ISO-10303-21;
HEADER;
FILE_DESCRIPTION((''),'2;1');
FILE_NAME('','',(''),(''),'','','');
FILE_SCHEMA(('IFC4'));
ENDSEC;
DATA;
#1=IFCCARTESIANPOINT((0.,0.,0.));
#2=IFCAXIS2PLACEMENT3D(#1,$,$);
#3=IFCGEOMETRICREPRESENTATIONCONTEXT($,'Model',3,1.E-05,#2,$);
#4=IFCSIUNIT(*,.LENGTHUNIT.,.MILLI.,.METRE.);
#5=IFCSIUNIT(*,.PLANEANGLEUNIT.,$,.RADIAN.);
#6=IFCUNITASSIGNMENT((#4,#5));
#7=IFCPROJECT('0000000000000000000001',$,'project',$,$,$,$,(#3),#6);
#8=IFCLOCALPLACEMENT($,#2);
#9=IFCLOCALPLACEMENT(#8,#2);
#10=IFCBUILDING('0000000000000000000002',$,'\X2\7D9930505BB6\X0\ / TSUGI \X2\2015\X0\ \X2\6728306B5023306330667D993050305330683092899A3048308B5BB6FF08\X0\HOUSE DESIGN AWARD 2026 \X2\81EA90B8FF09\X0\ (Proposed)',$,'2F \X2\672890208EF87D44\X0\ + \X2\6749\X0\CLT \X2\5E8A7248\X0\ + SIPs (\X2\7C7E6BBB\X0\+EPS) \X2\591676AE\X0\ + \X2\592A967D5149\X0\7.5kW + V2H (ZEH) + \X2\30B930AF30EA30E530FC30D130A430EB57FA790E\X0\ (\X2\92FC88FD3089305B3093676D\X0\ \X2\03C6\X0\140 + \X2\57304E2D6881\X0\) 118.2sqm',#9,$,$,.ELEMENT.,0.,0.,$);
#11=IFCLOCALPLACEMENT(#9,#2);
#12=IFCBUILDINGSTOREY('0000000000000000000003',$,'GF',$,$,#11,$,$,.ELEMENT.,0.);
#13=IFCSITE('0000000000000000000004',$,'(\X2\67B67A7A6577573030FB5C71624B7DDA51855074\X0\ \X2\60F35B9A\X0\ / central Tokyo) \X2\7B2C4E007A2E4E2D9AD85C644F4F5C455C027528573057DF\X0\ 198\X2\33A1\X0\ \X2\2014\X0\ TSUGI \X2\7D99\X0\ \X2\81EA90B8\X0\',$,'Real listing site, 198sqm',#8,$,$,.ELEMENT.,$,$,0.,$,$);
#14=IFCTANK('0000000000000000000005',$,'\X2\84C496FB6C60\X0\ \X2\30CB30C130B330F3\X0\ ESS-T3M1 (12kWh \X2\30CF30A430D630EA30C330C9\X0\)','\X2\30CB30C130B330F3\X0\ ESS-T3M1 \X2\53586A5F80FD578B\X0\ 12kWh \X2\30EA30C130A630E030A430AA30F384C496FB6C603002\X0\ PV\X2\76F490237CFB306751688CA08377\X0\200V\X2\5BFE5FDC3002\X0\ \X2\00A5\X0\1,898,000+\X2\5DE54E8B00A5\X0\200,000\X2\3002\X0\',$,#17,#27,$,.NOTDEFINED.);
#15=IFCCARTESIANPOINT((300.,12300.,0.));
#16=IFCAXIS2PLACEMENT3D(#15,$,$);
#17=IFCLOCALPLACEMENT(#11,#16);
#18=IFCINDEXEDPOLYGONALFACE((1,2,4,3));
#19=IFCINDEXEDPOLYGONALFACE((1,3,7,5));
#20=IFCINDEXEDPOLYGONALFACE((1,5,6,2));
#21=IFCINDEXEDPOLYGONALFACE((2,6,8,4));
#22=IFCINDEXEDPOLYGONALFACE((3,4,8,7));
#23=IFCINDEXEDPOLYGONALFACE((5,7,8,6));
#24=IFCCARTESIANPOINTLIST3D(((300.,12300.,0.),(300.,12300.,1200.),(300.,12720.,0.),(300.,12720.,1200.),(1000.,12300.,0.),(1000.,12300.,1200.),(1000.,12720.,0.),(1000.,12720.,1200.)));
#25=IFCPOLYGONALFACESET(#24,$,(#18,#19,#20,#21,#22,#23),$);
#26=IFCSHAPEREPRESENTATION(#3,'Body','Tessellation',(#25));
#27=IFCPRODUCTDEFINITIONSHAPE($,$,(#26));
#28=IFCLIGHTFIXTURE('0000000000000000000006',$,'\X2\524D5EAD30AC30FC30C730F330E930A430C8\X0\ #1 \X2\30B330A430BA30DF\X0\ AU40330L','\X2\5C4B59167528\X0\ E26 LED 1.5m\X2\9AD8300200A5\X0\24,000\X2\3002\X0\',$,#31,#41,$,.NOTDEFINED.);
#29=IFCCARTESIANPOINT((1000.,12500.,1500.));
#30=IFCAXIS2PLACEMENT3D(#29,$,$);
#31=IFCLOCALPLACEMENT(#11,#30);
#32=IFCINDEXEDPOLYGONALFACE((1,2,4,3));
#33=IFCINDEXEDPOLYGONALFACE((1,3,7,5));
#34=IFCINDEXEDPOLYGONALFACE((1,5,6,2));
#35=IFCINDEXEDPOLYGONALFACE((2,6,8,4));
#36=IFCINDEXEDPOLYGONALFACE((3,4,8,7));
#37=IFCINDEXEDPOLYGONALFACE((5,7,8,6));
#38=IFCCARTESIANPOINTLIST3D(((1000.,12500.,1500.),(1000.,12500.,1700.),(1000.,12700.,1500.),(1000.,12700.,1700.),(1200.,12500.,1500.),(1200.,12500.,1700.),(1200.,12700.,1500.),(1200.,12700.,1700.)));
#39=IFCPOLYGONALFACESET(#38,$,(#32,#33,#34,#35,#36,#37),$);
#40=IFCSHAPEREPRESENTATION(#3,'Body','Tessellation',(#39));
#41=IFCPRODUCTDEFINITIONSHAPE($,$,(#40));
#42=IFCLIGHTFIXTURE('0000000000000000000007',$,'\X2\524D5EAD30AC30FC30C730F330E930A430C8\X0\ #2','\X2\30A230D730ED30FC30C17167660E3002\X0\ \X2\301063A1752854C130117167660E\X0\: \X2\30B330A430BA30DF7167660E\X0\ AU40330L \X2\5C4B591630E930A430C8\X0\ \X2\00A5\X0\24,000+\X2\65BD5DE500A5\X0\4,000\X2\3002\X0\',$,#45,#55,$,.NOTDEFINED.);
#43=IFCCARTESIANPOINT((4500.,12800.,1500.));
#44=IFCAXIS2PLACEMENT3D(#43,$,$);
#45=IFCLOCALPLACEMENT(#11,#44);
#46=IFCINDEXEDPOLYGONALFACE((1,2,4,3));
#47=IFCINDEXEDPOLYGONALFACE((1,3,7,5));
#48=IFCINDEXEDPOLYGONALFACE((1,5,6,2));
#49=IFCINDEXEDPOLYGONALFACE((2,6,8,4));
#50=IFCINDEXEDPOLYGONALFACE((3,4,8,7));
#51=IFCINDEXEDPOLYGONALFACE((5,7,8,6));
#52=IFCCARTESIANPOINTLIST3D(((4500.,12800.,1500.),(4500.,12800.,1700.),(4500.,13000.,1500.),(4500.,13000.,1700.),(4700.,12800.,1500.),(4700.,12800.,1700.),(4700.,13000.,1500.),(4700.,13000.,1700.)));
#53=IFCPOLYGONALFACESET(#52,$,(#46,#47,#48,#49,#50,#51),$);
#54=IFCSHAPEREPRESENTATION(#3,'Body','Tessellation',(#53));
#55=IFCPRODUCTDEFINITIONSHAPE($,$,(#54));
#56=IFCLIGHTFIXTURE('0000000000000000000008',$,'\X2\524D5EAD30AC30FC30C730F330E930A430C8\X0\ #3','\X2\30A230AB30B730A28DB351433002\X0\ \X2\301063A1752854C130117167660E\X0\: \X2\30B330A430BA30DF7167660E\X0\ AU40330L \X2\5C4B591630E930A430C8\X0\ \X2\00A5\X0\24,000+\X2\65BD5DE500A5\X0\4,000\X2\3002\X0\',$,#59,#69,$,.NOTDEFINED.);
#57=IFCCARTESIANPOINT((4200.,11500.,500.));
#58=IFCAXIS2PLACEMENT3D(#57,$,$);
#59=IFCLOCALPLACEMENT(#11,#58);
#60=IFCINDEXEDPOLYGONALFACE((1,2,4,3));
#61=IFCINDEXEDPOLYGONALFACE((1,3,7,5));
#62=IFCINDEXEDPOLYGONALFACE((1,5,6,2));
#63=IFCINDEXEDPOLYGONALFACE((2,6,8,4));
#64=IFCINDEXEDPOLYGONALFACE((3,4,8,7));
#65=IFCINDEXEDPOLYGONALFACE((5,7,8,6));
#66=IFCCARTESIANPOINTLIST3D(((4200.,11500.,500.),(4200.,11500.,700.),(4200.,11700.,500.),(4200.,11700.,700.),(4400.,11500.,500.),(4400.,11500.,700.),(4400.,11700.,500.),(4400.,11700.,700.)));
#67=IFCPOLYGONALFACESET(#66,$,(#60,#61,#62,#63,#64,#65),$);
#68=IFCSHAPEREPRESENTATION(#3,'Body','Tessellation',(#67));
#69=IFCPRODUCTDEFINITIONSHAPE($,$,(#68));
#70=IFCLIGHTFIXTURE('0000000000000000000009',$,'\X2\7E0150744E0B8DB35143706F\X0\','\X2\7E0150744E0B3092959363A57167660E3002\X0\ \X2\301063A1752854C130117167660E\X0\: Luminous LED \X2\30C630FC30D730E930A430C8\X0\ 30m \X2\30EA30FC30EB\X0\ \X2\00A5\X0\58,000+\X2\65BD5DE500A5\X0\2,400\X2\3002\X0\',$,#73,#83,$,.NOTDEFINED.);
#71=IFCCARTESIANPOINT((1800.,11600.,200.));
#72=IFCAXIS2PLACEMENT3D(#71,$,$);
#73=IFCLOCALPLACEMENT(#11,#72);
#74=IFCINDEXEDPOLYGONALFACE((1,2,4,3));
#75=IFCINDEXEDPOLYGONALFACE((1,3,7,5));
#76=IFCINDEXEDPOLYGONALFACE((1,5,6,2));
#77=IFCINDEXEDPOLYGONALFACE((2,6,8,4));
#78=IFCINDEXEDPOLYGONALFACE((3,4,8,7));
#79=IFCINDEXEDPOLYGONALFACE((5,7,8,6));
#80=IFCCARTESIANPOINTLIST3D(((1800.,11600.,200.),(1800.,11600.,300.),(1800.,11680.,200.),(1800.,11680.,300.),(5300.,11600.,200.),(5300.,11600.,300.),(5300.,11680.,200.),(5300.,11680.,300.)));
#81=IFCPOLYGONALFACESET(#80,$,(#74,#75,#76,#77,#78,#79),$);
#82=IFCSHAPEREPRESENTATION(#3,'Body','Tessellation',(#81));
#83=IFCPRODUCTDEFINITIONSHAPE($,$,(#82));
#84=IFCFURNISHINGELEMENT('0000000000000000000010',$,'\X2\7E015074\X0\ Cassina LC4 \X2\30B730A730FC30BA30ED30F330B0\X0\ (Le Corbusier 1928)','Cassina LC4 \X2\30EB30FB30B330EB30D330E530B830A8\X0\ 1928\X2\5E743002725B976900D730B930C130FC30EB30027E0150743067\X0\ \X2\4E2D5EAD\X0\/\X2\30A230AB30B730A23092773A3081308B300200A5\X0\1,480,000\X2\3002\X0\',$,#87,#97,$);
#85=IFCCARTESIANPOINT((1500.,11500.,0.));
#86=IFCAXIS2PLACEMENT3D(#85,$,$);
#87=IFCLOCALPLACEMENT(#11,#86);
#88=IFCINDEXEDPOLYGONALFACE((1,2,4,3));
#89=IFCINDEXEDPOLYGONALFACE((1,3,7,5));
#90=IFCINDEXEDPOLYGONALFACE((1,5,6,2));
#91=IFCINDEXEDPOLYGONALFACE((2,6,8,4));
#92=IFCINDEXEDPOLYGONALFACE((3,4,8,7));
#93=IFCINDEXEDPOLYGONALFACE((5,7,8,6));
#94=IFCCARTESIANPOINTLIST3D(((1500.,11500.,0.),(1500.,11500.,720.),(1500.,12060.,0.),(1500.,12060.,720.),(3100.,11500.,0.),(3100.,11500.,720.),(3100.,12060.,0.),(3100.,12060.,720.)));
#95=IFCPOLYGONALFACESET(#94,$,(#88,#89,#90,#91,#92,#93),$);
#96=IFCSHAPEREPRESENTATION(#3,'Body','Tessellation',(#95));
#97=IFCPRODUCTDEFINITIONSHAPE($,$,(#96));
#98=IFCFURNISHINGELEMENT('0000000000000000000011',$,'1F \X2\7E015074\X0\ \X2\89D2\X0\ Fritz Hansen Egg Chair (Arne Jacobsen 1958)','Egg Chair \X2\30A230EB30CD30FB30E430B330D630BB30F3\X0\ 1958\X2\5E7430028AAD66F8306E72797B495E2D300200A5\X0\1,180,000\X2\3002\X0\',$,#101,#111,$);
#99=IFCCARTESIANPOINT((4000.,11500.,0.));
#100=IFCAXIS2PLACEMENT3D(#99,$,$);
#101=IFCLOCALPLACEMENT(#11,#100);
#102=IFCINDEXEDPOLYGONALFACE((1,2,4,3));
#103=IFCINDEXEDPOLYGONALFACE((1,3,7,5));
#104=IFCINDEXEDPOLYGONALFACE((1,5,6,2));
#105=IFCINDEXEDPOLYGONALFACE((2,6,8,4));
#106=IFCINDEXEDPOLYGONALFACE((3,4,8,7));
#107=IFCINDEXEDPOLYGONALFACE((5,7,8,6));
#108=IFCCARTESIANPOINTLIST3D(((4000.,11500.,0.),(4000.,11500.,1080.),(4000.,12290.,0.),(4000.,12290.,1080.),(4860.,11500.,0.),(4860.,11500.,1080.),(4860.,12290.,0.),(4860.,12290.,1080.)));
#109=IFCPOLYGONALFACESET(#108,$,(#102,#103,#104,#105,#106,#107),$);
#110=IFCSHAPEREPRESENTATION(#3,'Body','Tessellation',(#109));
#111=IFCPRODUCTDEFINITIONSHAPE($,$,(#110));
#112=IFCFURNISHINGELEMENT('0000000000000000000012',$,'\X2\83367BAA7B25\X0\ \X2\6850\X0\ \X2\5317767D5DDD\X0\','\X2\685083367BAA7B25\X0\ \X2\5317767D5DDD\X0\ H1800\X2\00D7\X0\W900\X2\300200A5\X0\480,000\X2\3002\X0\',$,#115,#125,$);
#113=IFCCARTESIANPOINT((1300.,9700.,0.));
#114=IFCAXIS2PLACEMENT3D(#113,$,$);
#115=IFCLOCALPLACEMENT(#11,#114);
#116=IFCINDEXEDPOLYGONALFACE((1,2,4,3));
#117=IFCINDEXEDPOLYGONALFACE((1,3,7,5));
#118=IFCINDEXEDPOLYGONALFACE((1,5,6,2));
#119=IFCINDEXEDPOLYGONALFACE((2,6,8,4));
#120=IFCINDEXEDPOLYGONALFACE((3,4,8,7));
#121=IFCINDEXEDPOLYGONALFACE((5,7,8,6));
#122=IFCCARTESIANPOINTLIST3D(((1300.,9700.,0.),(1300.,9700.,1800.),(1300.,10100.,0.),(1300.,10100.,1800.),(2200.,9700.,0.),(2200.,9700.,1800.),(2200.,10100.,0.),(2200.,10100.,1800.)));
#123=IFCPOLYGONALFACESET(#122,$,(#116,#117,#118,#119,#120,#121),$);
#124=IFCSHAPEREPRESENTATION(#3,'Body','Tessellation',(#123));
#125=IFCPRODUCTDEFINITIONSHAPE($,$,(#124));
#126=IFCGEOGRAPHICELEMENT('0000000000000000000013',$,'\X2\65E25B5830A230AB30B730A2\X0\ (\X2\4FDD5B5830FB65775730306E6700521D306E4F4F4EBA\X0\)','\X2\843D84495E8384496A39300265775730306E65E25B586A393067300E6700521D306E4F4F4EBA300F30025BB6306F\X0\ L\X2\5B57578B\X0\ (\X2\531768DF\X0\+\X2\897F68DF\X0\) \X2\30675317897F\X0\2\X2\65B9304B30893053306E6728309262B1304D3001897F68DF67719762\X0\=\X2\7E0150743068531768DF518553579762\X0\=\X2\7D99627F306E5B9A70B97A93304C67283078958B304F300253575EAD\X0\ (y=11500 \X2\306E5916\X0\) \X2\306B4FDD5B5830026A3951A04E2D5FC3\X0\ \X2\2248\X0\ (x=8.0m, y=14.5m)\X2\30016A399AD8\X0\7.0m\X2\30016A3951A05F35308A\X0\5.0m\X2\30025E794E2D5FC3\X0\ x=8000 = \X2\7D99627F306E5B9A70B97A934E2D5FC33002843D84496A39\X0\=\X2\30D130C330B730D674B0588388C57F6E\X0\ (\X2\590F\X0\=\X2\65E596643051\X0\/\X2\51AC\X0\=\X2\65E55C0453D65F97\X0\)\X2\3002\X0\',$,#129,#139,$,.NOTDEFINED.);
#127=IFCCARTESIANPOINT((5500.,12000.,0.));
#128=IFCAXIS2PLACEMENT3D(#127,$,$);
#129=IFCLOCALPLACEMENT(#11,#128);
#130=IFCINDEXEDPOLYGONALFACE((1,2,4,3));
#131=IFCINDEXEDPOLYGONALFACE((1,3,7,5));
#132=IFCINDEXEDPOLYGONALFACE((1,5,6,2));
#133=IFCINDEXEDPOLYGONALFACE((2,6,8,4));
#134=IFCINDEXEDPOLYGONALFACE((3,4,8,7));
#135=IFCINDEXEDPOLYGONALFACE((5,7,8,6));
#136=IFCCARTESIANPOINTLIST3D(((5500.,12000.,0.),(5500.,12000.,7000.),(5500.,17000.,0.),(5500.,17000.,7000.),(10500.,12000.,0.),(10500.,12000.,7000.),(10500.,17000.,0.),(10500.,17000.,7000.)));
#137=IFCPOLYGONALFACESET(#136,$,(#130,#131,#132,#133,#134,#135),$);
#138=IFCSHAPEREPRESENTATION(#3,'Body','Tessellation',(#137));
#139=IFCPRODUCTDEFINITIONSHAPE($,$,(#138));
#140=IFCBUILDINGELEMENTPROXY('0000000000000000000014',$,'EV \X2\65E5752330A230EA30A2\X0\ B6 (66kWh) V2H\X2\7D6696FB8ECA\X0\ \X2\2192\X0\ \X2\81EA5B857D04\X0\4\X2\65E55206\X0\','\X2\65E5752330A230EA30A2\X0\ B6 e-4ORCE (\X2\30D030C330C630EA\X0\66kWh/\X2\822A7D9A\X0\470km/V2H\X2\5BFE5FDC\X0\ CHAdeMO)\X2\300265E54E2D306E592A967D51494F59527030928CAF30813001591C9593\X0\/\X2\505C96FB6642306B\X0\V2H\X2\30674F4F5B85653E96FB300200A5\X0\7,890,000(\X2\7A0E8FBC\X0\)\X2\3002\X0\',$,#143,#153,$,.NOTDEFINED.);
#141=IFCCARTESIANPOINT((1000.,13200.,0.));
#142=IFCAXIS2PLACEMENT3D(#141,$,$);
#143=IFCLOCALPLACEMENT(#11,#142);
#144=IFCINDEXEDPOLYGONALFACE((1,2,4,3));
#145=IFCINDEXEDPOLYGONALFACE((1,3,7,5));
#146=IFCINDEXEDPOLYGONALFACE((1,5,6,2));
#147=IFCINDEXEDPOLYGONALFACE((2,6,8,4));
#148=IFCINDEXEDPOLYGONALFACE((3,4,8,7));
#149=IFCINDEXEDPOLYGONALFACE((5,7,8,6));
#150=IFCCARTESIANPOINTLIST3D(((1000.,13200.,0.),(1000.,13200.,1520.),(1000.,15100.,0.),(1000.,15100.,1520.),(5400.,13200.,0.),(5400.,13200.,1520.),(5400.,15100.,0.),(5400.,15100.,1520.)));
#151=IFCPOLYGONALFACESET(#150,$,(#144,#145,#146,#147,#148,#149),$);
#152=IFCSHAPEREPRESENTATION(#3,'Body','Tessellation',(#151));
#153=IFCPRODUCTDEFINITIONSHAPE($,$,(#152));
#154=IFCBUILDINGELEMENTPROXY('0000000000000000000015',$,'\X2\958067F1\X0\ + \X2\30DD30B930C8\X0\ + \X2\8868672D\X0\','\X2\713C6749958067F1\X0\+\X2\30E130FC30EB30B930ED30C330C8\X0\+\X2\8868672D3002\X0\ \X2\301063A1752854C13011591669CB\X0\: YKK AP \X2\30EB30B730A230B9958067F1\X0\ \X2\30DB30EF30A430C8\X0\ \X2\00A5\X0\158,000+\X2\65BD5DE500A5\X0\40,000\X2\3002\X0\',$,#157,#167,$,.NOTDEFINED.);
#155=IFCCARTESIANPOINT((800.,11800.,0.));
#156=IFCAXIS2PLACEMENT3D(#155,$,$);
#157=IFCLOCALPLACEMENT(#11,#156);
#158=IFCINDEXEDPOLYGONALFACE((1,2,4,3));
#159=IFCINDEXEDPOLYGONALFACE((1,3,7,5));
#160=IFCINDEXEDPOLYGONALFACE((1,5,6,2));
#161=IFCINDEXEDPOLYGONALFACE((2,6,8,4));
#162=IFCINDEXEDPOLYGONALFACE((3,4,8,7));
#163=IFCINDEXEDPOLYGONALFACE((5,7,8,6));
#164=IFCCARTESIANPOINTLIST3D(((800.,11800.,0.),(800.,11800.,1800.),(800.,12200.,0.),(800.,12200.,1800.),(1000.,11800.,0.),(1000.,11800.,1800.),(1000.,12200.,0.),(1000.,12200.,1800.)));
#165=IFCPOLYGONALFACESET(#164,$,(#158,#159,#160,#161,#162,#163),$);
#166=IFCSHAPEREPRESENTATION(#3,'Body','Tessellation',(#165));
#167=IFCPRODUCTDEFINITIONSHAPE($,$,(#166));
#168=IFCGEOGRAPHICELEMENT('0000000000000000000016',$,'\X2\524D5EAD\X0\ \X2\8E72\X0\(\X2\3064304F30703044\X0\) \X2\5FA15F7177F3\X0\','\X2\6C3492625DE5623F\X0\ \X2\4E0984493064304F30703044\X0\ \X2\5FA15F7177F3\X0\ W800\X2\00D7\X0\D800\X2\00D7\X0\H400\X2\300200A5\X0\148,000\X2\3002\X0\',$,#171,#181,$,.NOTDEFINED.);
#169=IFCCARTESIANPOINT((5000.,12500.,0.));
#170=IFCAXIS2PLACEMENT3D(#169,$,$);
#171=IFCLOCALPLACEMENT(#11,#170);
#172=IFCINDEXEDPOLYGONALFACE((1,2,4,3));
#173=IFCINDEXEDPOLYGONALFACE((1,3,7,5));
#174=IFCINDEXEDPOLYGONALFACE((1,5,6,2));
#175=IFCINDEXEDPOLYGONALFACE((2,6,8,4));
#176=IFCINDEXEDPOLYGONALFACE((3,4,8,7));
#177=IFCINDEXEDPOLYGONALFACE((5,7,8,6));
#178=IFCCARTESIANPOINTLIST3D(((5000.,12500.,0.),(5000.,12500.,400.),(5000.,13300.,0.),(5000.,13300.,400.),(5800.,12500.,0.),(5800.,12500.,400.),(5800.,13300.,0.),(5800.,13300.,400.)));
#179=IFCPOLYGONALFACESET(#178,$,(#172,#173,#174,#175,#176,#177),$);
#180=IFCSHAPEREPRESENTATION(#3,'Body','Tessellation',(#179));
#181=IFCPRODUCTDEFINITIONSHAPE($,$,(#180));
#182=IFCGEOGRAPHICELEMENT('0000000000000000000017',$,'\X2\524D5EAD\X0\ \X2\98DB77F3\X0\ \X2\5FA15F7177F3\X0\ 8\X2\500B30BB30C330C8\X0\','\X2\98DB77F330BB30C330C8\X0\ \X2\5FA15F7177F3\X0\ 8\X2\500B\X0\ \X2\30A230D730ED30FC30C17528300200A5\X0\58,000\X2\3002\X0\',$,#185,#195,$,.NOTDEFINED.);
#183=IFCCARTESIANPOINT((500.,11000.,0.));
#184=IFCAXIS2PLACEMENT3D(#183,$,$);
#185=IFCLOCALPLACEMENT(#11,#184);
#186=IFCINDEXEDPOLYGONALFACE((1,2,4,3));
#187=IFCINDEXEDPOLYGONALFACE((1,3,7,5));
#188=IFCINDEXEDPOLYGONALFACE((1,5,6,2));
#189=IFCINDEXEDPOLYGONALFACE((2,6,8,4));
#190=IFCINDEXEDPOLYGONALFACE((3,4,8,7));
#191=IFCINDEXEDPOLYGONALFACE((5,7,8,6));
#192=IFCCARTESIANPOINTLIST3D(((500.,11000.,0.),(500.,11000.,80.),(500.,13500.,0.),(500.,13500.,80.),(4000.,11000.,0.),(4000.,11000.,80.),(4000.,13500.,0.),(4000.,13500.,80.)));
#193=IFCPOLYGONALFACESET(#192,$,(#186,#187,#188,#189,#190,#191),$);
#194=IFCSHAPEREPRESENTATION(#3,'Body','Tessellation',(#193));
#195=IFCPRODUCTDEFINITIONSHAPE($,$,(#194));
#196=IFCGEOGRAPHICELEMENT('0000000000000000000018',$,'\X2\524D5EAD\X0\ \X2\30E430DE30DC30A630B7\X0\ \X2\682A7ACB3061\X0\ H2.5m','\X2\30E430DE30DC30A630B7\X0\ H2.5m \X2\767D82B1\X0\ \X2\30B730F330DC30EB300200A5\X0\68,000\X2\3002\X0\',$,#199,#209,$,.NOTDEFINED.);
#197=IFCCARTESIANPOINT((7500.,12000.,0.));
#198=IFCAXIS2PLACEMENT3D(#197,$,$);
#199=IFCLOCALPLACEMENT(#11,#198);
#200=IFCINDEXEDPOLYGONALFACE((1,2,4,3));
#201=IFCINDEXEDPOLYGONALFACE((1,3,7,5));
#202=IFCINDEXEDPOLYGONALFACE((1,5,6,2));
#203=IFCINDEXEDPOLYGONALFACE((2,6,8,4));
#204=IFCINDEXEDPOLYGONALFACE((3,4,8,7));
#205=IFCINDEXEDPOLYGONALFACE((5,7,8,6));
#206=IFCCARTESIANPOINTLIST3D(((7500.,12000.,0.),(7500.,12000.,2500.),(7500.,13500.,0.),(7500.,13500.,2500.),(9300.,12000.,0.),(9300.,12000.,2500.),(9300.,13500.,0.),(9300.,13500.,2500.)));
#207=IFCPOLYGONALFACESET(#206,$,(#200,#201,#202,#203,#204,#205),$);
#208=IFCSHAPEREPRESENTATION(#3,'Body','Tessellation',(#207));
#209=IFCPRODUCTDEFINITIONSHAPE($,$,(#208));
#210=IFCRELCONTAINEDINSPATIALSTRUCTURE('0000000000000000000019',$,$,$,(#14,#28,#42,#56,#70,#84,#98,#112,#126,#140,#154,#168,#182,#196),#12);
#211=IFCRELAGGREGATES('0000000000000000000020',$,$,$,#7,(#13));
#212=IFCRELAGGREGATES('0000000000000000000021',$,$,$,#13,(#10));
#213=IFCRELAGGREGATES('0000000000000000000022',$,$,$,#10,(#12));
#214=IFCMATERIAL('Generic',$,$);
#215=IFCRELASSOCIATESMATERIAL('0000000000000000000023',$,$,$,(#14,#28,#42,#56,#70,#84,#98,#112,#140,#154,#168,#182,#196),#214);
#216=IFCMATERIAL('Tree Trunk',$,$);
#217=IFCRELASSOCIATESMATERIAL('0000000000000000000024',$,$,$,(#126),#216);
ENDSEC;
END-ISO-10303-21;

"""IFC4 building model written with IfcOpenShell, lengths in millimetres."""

from ifc_helpers import new_model, si_unit, frame, frame_2d, origin, place, context, project, spatial, rectangle, extrude, material, element, save


model = new_model("IFC4")

# Units and contexts
model_context = context("Model", 3, precision=1e-05, world=origin())
ifc_project = project(units=[si_unit("LENGTHUNIT", "METRE", prefix="MILLI"), si_unit("PLANEANGLEUNIT", "RADIAN")], contexts=[model_context])

# Site, building, storey
site_placement = place(None, origin())
site = spatial("IfcSite", under=ifc_project, at=site_placement, Name="(架空敷地・山手線内側 想定 / central Tokyo) 第一種中高層住居専用地域 198㎡ — TSUGI 継 自邸", ObjectType="Real listing site, 198sqm", CompositionType="ELEMENT", RefElevation=0.0)
building_placement = place(site_placement, origin())
building = spatial("IfcBuilding", under=site, at=building_placement, Name="継ぐ家 / TSUGI ― 木に倣って継ぐことを覚える家（HOUSE DESIGN AWARD 2026 自邸） (Proposed)", ObjectType="2F 木造軸組 + 杉CLT 床版 + SIPs (籾殻+EPS) 外皮 + 太陽光7.5kW + V2H (ZEH) + スクリューパイル基礎 (鋼製らせん杭 φ140 + 地中梁) 118.2sqm", CompositionType="ELEMENT", ElevationOfRefHeight=0.0, ElevationOfTerrain=0.0)
storey_placement = place(building_placement, origin())
storey = spatial("IfcBuildingStorey", under=building, at=storey_placement, Name="GF", CompositionType="ELEMENT", Elevation=0.0)

# Shared definitions
ifc_material_1 = material(Name="Generic")

# Tank
tank_placement = place(storey_placement, frame((300.0, 12300.0, 0.0)))
element("IfcTank", 1, at=tank_placement, inside=storey, material=ifc_material_1, Name="蓄電池 ニチコン ESS-T3M1 (12kWh ハイブリッド)", Description="ニチコン ESS-T3M1 単機能型 12kWh リチウムイオン蓄電池。 PV直連系で全負荷200V対応。 ¥1,898,000+工事¥200,000。", PredefinedType="NOTDEFINED", context=model_context, shape_type="SweptSolid", body=[
    extrude(rectangle(XDim=700.0, YDim=420.0, at=frame_2d((350.0, 210.0))), frame((300.0, 12300.0, 0.0)), (0.0, 0.0, 1.0), 1200.0),
])

# Light fixtures
light_fixture_1_placement = place(storey_placement, frame((1000.0, 12500.0, 1500.0)))
element("IfcLightFixture", 2, at=light_fixture_1_placement, inside=storey, material=ifc_material_1, Name="前庭ガーデンライト #1 コイズミ AU40330L", Description="屋外用 E26 LED 1.5m高。¥24,000。", PredefinedType="NOTDEFINED", context=model_context, shape_type="SweptSolid", body=[
    extrude(rectangle(XDim=200.0, YDim=200.0, at=frame_2d((100.0, 100.0))), frame((1000.0, 12500.0, 1500.0)), (0.0, 0.0, 1.0), 200.0),
])
light_fixture_2_placement = place(storey_placement, frame((4500.0, 12800.0, 1500.0)))
element("IfcLightFixture", 3, at=light_fixture_2_placement, inside=storey, material=ifc_material_1, Name="前庭ガーデンライト #2", Description="アプローチ照明。 【採用品】照明: コイズミ照明 AU40330L 屋外ライト ¥24,000+施工¥4,000。", PredefinedType="NOTDEFINED", context=model_context, shape_type="SweptSolid", body=[
    extrude(rectangle(XDim=200.0, YDim=200.0, at=frame_2d((100.0, 100.0))), frame((4500.0, 12800.0, 1500.0)), (0.0, 0.0, 1.0), 200.0),
])
light_fixture_3_placement = place(storey_placement, frame((4200.0, 11500.0, 500.0)))
element("IfcLightFixture", 4, at=light_fixture_3_placement, inside=storey, material=ifc_material_1, Name="前庭ガーデンライト #3", Description="アカシア足元。 【採用品】照明: コイズミ照明 AU40330L 屋外ライト ¥24,000+施工¥4,000。", PredefinedType="NOTDEFINED", context=model_context, shape_type="SweptSolid", body=[
    extrude(rectangle(XDim=200.0, YDim=200.0, at=frame_2d((100.0, 100.0))), frame((4200.0, 11500.0, 500.0)), (0.0, 0.0, 1.0), 200.0),
])
light_fixture_4_placement = place(storey_placement, frame((1800.0, 11600.0, 200.0)))
element("IfcLightFixture", 5, at=light_fixture_4_placement, inside=storey, material=ifc_material_1, Name="縁側下足元灯", Description="縁側下を間接照明。 【採用品】照明: Luminous LED テープライト 30m リール ¥58,000+施工¥2,400。", PredefinedType="NOTDEFINED", context=model_context, shape_type="SweptSolid", body=[
    extrude(rectangle(XDim=3500.0, YDim=80.0, at=frame_2d((1750.0, 40.0))), frame((1800.0, 11600.0, 200.0)), (0.0, 0.0, 1.0), 100.0),
])

# Furnishing elements
furnishing_1_placement = place(storey_placement, frame((1500.0, 11500.0, 0.0)))
element("IfcFurnishingElement", 6, at=furnishing_1_placement, inside=storey, material=ifc_material_1, Name="縁側 Cassina LC4 シェーズロング (Le Corbusier 1928)", Description="Cassina LC4 ル・コルビュジエ 1928年。牛革×スチール。縁側で 中庭/アカシアを眺める。¥1,480,000。", context=model_context, shape_type="SweptSolid", body=[
    extrude(rectangle(XDim=1600.0, YDim=560.0, at=frame_2d((800.0, 280.0))), frame((1500.0, 11500.0, 0.0)), (0.0, 0.0, 1.0), 720.0),
])
furnishing_2_placement = place(storey_placement, frame((4000.0, 11500.0, 0.0)))
element("IfcFurnishingElement", 7, at=furnishing_2_placement, inside=storey, material=ifc_material_1, Name="1F 縁側 角 Fritz Hansen Egg Chair (Arne Jacobsen 1958)", Description="Egg Chair アルネ・ヤコブセン 1958年。読書の特等席。¥1,180,000。", context=model_context, shape_type="SweptSolid", body=[
    extrude(rectangle(XDim=860.0, YDim=790.0, at=frame_2d((430.0, 395.0))), frame((4000.0, 11500.0, 0.0)), (0.0, 0.0, 1.0), 1080.0),
])
furnishing_3_placement = place(storey_placement, frame((1300.0, 9700.0, 0.0)))
element("IfcFurnishingElement", 8, at=furnishing_3_placement, inside=storey, material=ifc_material_1, Name="茶箪笥 桐 北白川", Description="桐茶箪笥 北白川 H1800×W900。¥480,000。", context=model_context, shape_type="SweptSolid", body=[
    extrude(rectangle(XDim=900.0, YDim=400.0, at=frame_2d((450.0, 200.0))), frame((1300.0, 9700.0, 0.0)), (0.0, 0.0, 1.0), 1800.0),
])

# Geographic element
ifc_material_2 = material(Name="Tree Trunk")
geographic_element_1_placement = place(storey_placement, frame((5500.0, 12000.0, 0.0)))
element("IfcGeographicElement", 9, at=geographic_element_1_placement, inside=storey, material=ifc_material_2, Name="既存アカシア (保存・敷地の最初の住人)", Description="落葉広葉樹。敷地の既存樹で『最初の住人』。家は L字型 (北棟+西棟) で北西2方からこの木を抱き、西棟東面=縁側と北棟内南面=継承の定点窓が木へ開く。南庭 (y=11500 の外) に保存。樹冠中心 ≈ (x=8.0m, y=14.5m)、樹高7.0m、樹冠張り5.0m。幹中心 x=8000 = 継承の定点窓中心。落葉樹=パッシブ環境装置 (夏=日除け/冬=日射取得)。", PredefinedType="NOTDEFINED", context=model_context, shape_type="SweptSolid", body=[
    extrude(rectangle(XDim=5000.0, YDim=5000.0, at=frame_2d((2500.0, 2500.0))), frame((5500.0, 12000.0, 0.0)), (0.0, 0.0, 1.0), 7000.0),
])

# Building element proxies
proxy_1_placement = place(storey_placement, frame((1000.0, 13200.0, 0.0)))
element("IfcBuildingElementProxy", 10, at=proxy_1_placement, inside=storey, material=ifc_material_1, Name="EV 日産アリア B6 (66kWh) V2H給電車 → 自宅約4日分", Description="日産アリア B6 e-4ORCE (バッテリ66kWh/航続470km/V2H対応 CHAdeMO)。日中の太陽光余剰を貯め、夜間/停電時にV2Hで住宅放電。¥7,890,000(税込)。", PredefinedType="NOTDEFINED", context=model_context, shape_type="SweptSolid", body=[
    extrude(rectangle(XDim=4400.0, YDim=1900.0, at=frame_2d((2200.0, 950.0))), frame((1000.0, 13200.0, 0.0)), (0.0, 0.0, 1.0), 1520.0),
])
proxy_2_placement = place(storey_placement, frame((800.0, 11800.0, 0.0)))
element("IfcBuildingElementProxy", 11, at=proxy_2_placement, inside=storey, material=ifc_material_1, Name="門柱 + ポスト + 表札", Description="焼杉門柱+メールスロット+表札。 【採用品】外構: YKK AP ルシアス門柱 ホワイト ¥158,000+施工¥40,000。", PredefinedType="NOTDEFINED", context=model_context, shape_type="SweptSolid", body=[
    extrude(rectangle(XDim=200.0, YDim=400.0, at=frame_2d((100.0, 200.0))), frame((800.0, 11800.0, 0.0)), (0.0, 0.0, 1.0), 1800.0),
])

# Geographic elements
geographic_element_2_placement = place(storey_placement, frame((5000.0, 12500.0, 0.0)))
element("IfcGeographicElement", 12, at=geographic_element_2_placement, inside=storey, material=ifc_material_1, Name="前庭 蹲(つくばい) 御影石", Description="水鉢工房 三葉つくばい 御影石 W800×D800×H400。¥148,000。", PredefinedType="NOTDEFINED", context=model_context, shape_type="SweptSolid", body=[
    extrude(rectangle(XDim=800.0, YDim=800.0, at=frame_2d((400.0, 400.0))), frame((5000.0, 12500.0, 0.0)), (0.0, 0.0, 1.0), 400.0),
])
geographic_element_3_placement = place(storey_placement, frame((500.0, 11000.0, 0.0)))
element("IfcGeographicElement", 13, at=geographic_element_3_placement, inside=storey, material=ifc_material_1, Name="前庭 飛石 御影石 8個セット", Description="飛石セット 御影石 8個 アプローチ用。¥58,000。", PredefinedType="NOTDEFINED", context=model_context, shape_type="SweptSolid", body=[
    extrude(rectangle(XDim=3500.0, YDim=2500.0, at=frame_2d((1750.0, 1250.0))), frame((500.0, 11000.0, 0.0)), (0.0, 0.0, 1.0), 80.0),
])
geographic_element_4_placement = place(storey_placement, frame((7500.0, 12000.0, 0.0)))
element("IfcGeographicElement", 14, at=geographic_element_4_placement, inside=storey, material=ifc_material_1, Name="前庭 ヤマボウシ 株立ち H2.5m", Description="ヤマボウシ H2.5m 白花 シンボル。¥68,000。", PredefinedType="NOTDEFINED", context=model_context, shape_type="SweptSolid", body=[
    extrude(rectangle(XDim=1800.0, YDim=1500.0, at=frame_2d((900.0, 750.0))), frame((7500.0, 12000.0, 0.0)), (0.0, 0.0, 1.0), 2500.0),
])

save(model, "model.ifc")
